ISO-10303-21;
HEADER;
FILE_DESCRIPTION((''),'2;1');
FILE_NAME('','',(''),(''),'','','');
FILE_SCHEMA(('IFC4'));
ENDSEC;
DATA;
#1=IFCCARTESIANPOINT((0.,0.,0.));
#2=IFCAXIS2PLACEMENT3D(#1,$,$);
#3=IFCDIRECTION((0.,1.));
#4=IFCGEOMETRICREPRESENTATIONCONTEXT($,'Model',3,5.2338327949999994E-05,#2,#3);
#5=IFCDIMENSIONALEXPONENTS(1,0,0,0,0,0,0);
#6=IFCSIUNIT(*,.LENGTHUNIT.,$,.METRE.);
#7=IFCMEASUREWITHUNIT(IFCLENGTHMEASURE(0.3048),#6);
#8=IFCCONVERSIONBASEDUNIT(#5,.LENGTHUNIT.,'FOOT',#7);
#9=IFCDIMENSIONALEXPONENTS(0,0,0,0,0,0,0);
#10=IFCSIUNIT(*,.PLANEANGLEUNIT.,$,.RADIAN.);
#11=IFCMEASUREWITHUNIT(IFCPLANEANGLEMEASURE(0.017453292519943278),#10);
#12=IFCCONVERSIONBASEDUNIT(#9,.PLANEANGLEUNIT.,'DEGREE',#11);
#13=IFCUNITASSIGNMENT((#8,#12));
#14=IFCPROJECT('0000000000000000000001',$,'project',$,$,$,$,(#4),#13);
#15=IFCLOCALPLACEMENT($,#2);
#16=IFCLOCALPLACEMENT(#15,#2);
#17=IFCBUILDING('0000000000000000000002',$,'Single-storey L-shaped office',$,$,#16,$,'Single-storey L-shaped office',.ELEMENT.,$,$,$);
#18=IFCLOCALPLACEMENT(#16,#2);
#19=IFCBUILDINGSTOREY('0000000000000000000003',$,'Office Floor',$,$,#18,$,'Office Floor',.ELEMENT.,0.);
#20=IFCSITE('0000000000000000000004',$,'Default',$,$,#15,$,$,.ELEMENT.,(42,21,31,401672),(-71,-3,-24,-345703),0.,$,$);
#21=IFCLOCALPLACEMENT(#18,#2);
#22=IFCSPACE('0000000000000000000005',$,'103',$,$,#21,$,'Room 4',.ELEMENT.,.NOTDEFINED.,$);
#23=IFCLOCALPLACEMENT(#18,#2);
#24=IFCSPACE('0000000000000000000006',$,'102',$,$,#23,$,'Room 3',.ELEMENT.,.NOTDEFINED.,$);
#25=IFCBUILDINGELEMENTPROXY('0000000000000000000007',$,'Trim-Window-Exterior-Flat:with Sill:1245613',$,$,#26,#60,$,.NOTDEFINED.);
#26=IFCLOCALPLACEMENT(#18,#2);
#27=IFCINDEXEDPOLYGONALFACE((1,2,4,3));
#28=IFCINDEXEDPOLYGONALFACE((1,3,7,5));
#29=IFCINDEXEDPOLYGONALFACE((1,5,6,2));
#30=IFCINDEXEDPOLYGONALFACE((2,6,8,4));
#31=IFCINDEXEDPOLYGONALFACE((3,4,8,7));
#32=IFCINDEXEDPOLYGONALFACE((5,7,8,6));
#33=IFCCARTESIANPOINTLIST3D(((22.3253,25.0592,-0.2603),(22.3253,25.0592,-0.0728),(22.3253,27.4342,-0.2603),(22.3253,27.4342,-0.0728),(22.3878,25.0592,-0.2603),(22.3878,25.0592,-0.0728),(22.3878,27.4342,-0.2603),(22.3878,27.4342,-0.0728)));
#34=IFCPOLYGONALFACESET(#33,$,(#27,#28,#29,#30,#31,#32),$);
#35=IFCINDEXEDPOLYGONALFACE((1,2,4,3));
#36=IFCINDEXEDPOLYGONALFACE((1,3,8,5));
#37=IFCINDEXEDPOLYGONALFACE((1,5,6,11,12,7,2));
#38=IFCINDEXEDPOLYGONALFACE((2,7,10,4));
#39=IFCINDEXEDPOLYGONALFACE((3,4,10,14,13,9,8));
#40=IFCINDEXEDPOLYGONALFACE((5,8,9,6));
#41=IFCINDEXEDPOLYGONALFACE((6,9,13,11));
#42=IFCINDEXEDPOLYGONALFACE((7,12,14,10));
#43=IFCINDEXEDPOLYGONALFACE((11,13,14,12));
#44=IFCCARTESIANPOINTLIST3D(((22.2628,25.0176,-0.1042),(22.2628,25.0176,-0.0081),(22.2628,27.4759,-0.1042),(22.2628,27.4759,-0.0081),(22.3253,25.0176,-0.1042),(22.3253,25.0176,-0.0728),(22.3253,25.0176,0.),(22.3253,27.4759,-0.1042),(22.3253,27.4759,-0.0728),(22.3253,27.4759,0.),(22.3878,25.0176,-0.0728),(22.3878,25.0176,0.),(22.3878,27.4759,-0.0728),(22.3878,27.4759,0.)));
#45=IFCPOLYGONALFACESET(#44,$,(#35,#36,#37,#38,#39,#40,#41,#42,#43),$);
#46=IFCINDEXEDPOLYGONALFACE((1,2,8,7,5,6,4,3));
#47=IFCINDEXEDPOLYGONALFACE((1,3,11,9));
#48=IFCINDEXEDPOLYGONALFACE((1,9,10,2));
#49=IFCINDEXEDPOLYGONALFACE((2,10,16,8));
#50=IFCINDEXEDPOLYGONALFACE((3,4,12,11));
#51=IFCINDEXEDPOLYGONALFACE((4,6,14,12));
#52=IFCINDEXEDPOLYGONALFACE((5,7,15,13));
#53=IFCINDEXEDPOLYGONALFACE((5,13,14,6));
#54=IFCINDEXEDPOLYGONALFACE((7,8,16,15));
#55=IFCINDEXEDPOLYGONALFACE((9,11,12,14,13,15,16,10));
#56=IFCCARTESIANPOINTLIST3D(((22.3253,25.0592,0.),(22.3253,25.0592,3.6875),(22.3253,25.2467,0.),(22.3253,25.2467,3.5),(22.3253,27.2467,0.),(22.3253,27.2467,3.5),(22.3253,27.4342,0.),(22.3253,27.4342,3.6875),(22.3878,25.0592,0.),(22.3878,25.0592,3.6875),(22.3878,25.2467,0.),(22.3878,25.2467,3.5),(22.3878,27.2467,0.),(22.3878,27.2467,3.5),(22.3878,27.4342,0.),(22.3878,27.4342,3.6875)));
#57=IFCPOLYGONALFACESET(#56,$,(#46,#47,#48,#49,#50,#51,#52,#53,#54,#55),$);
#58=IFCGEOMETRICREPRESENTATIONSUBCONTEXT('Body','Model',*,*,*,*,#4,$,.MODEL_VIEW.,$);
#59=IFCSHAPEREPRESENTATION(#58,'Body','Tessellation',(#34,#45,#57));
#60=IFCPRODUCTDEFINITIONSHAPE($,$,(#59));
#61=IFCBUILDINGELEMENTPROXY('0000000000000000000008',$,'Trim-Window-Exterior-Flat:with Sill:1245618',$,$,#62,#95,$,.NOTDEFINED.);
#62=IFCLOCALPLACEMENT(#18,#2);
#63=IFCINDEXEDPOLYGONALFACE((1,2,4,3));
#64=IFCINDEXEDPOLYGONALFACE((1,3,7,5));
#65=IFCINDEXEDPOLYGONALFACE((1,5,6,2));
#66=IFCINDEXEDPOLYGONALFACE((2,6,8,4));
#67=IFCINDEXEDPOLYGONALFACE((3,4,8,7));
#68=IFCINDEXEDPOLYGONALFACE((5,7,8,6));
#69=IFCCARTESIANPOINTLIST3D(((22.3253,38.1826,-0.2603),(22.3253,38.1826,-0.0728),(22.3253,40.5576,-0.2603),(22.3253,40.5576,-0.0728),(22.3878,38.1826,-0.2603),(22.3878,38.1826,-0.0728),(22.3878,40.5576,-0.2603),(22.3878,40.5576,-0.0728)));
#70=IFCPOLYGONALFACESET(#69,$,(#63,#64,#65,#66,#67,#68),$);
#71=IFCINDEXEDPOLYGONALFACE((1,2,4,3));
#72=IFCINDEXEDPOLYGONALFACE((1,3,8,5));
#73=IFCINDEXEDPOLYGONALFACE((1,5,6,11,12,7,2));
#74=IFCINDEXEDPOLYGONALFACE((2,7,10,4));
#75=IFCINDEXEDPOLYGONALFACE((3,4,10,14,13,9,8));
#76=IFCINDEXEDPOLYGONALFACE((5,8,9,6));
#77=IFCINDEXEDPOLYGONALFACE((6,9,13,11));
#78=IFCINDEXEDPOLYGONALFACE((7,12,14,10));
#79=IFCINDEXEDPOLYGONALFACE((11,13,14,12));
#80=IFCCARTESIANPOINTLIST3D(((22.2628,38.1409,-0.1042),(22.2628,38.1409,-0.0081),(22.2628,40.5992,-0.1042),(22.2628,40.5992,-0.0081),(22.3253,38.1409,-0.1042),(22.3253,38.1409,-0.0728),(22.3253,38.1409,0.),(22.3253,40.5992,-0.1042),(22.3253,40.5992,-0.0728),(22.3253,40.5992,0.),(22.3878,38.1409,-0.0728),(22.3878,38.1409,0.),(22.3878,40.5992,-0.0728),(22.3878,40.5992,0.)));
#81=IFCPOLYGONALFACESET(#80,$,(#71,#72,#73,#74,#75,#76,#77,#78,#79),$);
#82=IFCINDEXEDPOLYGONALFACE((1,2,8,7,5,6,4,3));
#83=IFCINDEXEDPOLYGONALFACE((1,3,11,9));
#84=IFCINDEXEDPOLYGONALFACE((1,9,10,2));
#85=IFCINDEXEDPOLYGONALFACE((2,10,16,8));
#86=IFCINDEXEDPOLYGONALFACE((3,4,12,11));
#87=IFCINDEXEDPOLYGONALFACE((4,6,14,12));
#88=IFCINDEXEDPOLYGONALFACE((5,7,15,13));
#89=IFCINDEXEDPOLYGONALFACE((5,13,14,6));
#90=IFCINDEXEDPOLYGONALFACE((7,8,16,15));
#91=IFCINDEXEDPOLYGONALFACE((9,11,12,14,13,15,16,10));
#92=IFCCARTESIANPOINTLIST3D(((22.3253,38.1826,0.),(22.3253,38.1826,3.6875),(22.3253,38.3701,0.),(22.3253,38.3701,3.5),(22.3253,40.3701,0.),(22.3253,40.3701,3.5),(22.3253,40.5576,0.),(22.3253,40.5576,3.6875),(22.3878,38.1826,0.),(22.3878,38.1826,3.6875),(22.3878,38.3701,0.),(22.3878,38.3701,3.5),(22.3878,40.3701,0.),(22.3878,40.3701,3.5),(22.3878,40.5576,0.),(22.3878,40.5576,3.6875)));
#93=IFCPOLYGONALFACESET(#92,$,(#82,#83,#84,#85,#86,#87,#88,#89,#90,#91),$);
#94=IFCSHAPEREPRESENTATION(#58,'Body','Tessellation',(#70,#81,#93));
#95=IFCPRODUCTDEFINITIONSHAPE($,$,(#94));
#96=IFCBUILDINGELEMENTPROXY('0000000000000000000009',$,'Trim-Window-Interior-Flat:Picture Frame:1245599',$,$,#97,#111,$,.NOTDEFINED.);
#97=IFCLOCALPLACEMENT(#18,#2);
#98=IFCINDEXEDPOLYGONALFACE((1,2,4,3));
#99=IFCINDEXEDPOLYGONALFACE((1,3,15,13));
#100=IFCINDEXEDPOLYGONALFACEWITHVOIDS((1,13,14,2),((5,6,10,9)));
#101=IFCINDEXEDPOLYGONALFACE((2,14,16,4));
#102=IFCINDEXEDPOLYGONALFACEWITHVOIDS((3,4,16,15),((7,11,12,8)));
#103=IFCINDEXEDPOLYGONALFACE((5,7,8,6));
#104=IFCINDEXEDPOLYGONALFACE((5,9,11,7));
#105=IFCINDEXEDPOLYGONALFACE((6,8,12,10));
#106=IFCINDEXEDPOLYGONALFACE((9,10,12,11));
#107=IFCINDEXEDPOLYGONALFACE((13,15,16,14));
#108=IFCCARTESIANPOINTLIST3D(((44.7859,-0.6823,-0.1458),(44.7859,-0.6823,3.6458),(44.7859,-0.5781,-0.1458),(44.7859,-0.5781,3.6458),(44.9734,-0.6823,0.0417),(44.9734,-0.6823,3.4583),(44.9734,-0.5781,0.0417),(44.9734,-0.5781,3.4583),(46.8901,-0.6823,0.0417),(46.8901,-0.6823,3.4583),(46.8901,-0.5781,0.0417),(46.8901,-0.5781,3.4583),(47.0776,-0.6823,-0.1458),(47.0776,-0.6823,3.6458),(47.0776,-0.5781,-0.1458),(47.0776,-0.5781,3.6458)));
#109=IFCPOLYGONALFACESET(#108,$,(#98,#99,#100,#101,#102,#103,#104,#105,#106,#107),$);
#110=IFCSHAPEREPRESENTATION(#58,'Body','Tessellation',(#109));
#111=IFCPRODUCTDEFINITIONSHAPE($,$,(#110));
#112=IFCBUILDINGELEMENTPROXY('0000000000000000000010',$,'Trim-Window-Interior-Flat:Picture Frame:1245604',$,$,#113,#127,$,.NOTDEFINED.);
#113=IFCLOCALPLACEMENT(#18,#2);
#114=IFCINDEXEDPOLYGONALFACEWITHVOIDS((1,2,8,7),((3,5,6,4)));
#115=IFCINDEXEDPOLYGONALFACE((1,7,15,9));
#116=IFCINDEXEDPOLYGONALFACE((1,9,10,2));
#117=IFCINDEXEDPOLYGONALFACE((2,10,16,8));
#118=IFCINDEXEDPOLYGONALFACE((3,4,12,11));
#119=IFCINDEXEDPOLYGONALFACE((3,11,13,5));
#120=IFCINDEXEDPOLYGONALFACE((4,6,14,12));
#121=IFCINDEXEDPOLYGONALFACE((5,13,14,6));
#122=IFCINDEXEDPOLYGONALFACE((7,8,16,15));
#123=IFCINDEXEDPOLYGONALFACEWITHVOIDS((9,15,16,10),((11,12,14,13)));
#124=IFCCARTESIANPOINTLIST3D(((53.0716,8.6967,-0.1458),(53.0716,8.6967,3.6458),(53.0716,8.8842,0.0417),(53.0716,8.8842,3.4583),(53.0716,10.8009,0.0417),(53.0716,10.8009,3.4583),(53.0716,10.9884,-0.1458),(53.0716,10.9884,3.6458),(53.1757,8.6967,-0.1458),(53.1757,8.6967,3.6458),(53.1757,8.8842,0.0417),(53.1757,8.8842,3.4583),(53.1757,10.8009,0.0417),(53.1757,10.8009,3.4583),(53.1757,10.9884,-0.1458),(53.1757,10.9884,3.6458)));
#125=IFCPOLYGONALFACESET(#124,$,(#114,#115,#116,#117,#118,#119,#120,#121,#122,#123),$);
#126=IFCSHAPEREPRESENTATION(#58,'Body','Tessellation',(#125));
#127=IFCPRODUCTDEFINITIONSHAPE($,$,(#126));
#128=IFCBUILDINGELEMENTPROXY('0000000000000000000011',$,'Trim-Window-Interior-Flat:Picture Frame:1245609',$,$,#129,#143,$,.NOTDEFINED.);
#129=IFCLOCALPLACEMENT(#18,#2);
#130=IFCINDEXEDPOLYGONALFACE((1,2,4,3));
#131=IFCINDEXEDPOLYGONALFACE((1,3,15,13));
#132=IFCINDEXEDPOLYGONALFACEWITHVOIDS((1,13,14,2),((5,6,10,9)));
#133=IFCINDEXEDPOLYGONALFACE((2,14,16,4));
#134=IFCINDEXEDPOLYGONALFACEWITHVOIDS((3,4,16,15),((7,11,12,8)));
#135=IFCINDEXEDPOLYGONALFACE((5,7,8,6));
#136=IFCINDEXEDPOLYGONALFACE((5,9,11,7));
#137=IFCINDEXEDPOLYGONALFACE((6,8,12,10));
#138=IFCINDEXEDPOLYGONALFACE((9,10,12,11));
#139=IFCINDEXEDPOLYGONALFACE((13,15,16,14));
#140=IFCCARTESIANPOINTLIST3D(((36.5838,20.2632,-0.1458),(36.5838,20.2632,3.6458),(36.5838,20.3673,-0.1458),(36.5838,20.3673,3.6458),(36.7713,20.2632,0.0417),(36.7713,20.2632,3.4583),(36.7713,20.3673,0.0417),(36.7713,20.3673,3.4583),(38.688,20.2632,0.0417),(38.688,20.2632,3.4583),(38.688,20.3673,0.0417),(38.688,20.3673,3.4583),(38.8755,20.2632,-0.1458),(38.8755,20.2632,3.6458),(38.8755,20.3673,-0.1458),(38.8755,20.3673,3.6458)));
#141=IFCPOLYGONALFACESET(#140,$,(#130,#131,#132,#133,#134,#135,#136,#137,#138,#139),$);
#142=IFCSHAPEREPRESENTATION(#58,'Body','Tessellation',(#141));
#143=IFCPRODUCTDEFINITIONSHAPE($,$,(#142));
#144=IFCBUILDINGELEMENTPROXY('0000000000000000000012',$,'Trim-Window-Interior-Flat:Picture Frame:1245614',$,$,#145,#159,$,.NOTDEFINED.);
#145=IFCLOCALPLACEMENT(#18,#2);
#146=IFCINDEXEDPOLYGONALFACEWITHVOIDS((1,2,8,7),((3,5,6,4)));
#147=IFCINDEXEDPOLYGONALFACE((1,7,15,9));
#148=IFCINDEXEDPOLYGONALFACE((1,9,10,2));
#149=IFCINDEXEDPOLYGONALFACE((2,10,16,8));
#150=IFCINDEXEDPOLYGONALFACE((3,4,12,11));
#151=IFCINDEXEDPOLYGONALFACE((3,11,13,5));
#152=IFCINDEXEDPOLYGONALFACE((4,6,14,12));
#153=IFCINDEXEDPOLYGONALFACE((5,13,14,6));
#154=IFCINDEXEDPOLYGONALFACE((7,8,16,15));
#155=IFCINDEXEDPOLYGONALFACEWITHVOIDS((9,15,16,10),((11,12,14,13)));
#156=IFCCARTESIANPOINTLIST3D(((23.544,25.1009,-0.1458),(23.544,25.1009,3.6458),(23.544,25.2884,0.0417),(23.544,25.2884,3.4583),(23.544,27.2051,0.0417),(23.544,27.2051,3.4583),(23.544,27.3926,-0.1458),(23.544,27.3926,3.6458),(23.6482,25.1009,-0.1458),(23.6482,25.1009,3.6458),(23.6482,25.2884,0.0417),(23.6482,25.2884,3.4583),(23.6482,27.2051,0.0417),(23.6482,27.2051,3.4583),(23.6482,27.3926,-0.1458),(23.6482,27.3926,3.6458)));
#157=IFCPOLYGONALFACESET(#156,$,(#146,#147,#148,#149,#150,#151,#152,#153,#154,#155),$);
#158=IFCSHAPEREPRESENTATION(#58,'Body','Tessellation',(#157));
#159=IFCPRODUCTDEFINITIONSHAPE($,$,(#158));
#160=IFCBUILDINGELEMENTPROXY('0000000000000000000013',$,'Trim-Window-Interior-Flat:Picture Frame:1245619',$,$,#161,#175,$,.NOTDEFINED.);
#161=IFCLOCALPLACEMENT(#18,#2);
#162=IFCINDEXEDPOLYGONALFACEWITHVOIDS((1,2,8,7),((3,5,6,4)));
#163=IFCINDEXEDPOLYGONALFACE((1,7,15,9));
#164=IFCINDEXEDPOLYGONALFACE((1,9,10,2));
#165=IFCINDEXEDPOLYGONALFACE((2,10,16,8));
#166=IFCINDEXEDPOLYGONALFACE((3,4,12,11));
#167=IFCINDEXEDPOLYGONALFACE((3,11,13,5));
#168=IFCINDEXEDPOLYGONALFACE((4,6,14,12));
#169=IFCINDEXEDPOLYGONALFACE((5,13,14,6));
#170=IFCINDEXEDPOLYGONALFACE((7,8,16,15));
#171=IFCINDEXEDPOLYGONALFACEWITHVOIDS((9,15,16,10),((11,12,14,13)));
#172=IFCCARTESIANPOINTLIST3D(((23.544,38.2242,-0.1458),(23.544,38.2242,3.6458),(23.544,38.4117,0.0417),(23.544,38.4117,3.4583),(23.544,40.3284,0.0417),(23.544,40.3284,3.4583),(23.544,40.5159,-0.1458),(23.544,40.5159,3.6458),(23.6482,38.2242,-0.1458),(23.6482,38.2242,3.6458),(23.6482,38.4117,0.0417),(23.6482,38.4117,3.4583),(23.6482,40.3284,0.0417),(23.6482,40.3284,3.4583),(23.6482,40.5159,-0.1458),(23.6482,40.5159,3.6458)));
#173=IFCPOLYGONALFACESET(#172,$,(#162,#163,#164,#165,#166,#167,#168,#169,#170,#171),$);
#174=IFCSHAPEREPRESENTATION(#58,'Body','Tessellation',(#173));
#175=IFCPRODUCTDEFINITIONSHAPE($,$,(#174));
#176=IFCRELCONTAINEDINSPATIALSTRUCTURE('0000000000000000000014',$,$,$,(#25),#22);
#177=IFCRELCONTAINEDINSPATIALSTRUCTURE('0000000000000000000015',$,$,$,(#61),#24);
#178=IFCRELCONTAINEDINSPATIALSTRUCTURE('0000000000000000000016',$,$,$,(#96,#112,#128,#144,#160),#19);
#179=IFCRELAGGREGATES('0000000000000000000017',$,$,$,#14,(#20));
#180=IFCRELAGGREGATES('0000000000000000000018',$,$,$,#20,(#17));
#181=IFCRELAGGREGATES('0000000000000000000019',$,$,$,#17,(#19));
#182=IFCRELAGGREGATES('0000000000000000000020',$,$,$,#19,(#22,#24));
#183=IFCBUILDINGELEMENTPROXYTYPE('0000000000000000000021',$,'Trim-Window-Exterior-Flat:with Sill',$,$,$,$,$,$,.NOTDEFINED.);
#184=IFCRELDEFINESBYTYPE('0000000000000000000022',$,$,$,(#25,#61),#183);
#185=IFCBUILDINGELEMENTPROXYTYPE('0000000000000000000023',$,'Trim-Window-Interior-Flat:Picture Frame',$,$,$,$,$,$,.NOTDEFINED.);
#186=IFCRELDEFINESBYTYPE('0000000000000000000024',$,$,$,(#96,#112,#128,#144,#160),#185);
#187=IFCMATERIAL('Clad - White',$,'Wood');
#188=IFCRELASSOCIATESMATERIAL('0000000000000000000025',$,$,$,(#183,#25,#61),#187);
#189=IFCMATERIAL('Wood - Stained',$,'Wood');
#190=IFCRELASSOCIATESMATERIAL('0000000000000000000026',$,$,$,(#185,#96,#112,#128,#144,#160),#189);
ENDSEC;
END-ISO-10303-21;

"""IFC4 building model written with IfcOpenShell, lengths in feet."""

from ifc_helpers import new_model, entity, si_unit, converted_unit, direction, frame, origin, place, context, subcontext, project, spatial, indexed_curve, outline, extrude, source, transform, mapped, material, type_object, type_shapes, element, save


model = new_model("IFC4")

# Units and contexts
model_context = context("Model", 3, precision=5.2338327949999994e-05, world=origin(), true_north=direction((0.0, 1.0)))
body_context = subcontext(model_context, "Body", "Model", "MODEL_VIEW")
ifc_project = project(units=[converted_unit("LENGTHUNIT", "FOOT", entity("IfcLengthMeasure", 0.3048), si_unit("LENGTHUNIT", "METRE"), dimensions=[1, 0, 0, 0, 0, 0, 0]), converted_unit("PLANEANGLEUNIT", "DEGREE", entity("IfcPlaneAngleMeasure", 0.017453292519943278), si_unit("PLANEANGLEUNIT", "RADIAN"), dimensions=[0, 0, 0, 0, 0, 0, 0])], contexts=[model_context])

# Site, building, storey
site_placement = place(None, origin())
site = spatial("IfcSite", under=ifc_project, at=site_placement, Name="Default", CompositionType="ELEMENT", RefLatitude=(42, 21, 31, 401672), RefLongitude=(-71, -3, -24, -345703), RefElevation=0.0)
building_placement = place(site_placement, origin())
building = spatial("IfcBuilding", under=site, at=building_placement, Name="Single-storey L-shaped office", LongName="Single-storey L-shaped office", CompositionType="ELEMENT")
storey_placement = place(building_placement, origin())
storey = spatial("IfcBuildingStorey", under=building, at=storey_placement, Name="Office Floor", LongName="Office Floor", CompositionType="ELEMENT", Elevation=0.0)

# Shared definitions
ifc_material_1 = material(Name="Wood - Stained", Category="Wood")

# Shared definitions
ifc_material_2 = material(Name="Clad - White", Category="Wood")

# Shared definitions
building_element_proxy_type_1 = type_object("IfcBuildingElementProxyType", Name="Trim-Window-Exterior-Flat:with Sill", PredefinedType="NOTDEFINED", material=ifc_material_2)
shared_shape_1 = source(origin(), body_context, "Body", "SweptSolid", [
    extrude(outline(indexed_curve([(-1.1875, -0.0938), (1.1875, -0.0938), (1.1875, 0.0938), (-1.1875, 0.0938), (-1.1875, -0.0938)], self_intersect=False)), frame((0.0, -3.6665, 0.0), z_axis=(0.0, 0.0, 1.0), x_axis=(-1.0, 0.0, 0.0)), (0.0, 0.0, 1.0), 0.0625),
    extrude(outline(indexed_curve([(-0.0625, -0.0525), (0.0, -0.0525), (0.0, -0.0211), (0.0625, -0.0211), (0.0625, 0.0517), (0.0, 0.0517), (-0.0625, 0.0436), (-0.0625, -0.0525)], self_intersect=False)), frame((-1.2292, -3.5517, 0.0625), z_axis=(1.0, 0.0, 0.0), x_axis=(0.0, 0.0, -1.0)), (0.0, 0.0, 1.0), 2.4583),
    extrude(outline(indexed_curve([(-1.8906, -1.1875), (1.7969, -1.1875), (1.7969, -1.0), (-1.7031, -1.0), (-1.7031, 1.0), (1.7969, 1.0), (1.7969, 1.1875), (-1.8906, 1.1875), (-1.8906, -1.1875)], self_intersect=False)), frame((0.0, -1.7031, 0.0), z_axis=(0.0, 0.0, 1.0), x_axis=(0.0, -1.0, 0.0)), (0.0, 0.0, 1.0), 0.0625),
])
type_shapes(building_element_proxy_type_1, [shared_shape_1])

# Shared definitions
space_1_placement = place(storey_placement, origin())
space_1 = spatial("IfcSpace", under=storey, at=space_1_placement, Name="103", LongName="Room 4", CompositionType="ELEMENT", PredefinedType="NOTDEFINED")

# Building element proxy
proxy_1_placement = place(space_1_placement, frame((22.3878, 26.2467, 3.5), z_axis=(-1.0, 0.0, 0.0), x_axis=(0.0, -1.0, 0.0)))
element("IfcBuildingElementProxy", 1, at=proxy_1_placement, inside=space_1, type_object=building_element_proxy_type_1, material=ifc_material_2, Name="Trim-Window-Exterior-Flat:with Sill:1245613", PredefinedType="NOTDEFINED", context=body_context, shape_type="MappedRepresentation", body=[
    mapped(shared_shape_1, transform((0.0, 0.0, 0.0), scale=1.0)),
])

# Shared definitions
space_2_placement = place(storey_placement, origin())
space_2 = spatial("IfcSpace", under=storey, at=space_2_placement, Name="102", LongName="Room 3", CompositionType="ELEMENT", PredefinedType="NOTDEFINED")

# Building element proxies
proxy_2_placement = place(space_2_placement, frame((22.3878, 39.3701, 3.5), z_axis=(-1.0, 0.0, 0.0), x_axis=(0.0, -1.0, 0.0)))
element("IfcBuildingElementProxy", 2, at=proxy_2_placement, inside=space_2, type_object=building_element_proxy_type_1, material=ifc_material_2, Name="Trim-Window-Exterior-Flat:with Sill:1245618", PredefinedType="NOTDEFINED", context=body_context, shape_type="MappedRepresentation", body=[
    mapped(shared_shape_1, transform((0.0, 0.0, 0.0), scale=1.0)),
])
building_element_proxy_type_2 = type_object("IfcBuildingElementProxyType", Name="Trim-Window-Interior-Flat:Picture Frame", PredefinedType="NOTDEFINED", material=ifc_material_1)
shared_shape_2 = source(origin(), body_context, "Body", "SweptSolid", [
    extrude(outline(indexed_curve([(-1.1458, -1.8958), (1.1458, -1.8958), (1.1458, 1.8958), (-1.1458, 1.8958), (-1.1458, -1.8958)], self_intersect=False), holes=[indexed_curve([(-0.9583, -1.7083), (-0.9583, 1.7083), (0.9583, 1.7083), (0.9583, -1.7083), (-0.9583, -1.7083)], self_intersect=False)]), frame((0.0, -1.75, 0.0), z_axis=(0.0, 0.0, 1.0), x_axis=(-1.0, 0.0, 0.0)), (0.0, 0.0, 1.0), 0.1042),
])
type_shapes(building_element_proxy_type_2, [shared_shape_2])
for number, where, z_axis, x_axis, name in (
    (3, (45.9318, -0.5781, 3.5), (0.0, -1.0, 0.0), (1.0, 0.0, 0.0), "Trim-Window-Interior-Flat:Picture Frame:1245599"),
    (4, (53.0716, 9.8425, 3.5), (1.0, 0.0, 0.0), (0.0, 1.0, 0.0), "Trim-Window-Interior-Flat:Picture Frame:1245604"),
    (5, (37.7297, 20.2632, 3.5), (0.0, 1.0, 0.0), (-1.0, 0.0, 0.0), "Trim-Window-Interior-Flat:Picture Frame:1245609"),
    (6, (23.544, 26.2467, 3.5), (1.0, 0.0, 0.0), (0.0, 1.0, 0.0), "Trim-Window-Interior-Flat:Picture Frame:1245614"),
    (7, (23.544, 39.3701, 3.5), (1.0, 0.0, 0.0), (0.0, 1.0, 0.0), "Trim-Window-Interior-Flat:Picture Frame:1245619"),
):
    element("IfcBuildingElementProxy", number, at=place(storey_placement, frame(where, z_axis=z_axis, x_axis=x_axis)), inside=storey, type_object=building_element_proxy_type_2, material=ifc_material_1, Name=name, PredefinedType="NOTDEFINED", context=body_context, shape_type="MappedRepresentation", body=[
        mapped(shared_shape_2, transform((0.0, 0.0, 0.0), scale=1.0)),
    ])

save(model, "model.ifc")
